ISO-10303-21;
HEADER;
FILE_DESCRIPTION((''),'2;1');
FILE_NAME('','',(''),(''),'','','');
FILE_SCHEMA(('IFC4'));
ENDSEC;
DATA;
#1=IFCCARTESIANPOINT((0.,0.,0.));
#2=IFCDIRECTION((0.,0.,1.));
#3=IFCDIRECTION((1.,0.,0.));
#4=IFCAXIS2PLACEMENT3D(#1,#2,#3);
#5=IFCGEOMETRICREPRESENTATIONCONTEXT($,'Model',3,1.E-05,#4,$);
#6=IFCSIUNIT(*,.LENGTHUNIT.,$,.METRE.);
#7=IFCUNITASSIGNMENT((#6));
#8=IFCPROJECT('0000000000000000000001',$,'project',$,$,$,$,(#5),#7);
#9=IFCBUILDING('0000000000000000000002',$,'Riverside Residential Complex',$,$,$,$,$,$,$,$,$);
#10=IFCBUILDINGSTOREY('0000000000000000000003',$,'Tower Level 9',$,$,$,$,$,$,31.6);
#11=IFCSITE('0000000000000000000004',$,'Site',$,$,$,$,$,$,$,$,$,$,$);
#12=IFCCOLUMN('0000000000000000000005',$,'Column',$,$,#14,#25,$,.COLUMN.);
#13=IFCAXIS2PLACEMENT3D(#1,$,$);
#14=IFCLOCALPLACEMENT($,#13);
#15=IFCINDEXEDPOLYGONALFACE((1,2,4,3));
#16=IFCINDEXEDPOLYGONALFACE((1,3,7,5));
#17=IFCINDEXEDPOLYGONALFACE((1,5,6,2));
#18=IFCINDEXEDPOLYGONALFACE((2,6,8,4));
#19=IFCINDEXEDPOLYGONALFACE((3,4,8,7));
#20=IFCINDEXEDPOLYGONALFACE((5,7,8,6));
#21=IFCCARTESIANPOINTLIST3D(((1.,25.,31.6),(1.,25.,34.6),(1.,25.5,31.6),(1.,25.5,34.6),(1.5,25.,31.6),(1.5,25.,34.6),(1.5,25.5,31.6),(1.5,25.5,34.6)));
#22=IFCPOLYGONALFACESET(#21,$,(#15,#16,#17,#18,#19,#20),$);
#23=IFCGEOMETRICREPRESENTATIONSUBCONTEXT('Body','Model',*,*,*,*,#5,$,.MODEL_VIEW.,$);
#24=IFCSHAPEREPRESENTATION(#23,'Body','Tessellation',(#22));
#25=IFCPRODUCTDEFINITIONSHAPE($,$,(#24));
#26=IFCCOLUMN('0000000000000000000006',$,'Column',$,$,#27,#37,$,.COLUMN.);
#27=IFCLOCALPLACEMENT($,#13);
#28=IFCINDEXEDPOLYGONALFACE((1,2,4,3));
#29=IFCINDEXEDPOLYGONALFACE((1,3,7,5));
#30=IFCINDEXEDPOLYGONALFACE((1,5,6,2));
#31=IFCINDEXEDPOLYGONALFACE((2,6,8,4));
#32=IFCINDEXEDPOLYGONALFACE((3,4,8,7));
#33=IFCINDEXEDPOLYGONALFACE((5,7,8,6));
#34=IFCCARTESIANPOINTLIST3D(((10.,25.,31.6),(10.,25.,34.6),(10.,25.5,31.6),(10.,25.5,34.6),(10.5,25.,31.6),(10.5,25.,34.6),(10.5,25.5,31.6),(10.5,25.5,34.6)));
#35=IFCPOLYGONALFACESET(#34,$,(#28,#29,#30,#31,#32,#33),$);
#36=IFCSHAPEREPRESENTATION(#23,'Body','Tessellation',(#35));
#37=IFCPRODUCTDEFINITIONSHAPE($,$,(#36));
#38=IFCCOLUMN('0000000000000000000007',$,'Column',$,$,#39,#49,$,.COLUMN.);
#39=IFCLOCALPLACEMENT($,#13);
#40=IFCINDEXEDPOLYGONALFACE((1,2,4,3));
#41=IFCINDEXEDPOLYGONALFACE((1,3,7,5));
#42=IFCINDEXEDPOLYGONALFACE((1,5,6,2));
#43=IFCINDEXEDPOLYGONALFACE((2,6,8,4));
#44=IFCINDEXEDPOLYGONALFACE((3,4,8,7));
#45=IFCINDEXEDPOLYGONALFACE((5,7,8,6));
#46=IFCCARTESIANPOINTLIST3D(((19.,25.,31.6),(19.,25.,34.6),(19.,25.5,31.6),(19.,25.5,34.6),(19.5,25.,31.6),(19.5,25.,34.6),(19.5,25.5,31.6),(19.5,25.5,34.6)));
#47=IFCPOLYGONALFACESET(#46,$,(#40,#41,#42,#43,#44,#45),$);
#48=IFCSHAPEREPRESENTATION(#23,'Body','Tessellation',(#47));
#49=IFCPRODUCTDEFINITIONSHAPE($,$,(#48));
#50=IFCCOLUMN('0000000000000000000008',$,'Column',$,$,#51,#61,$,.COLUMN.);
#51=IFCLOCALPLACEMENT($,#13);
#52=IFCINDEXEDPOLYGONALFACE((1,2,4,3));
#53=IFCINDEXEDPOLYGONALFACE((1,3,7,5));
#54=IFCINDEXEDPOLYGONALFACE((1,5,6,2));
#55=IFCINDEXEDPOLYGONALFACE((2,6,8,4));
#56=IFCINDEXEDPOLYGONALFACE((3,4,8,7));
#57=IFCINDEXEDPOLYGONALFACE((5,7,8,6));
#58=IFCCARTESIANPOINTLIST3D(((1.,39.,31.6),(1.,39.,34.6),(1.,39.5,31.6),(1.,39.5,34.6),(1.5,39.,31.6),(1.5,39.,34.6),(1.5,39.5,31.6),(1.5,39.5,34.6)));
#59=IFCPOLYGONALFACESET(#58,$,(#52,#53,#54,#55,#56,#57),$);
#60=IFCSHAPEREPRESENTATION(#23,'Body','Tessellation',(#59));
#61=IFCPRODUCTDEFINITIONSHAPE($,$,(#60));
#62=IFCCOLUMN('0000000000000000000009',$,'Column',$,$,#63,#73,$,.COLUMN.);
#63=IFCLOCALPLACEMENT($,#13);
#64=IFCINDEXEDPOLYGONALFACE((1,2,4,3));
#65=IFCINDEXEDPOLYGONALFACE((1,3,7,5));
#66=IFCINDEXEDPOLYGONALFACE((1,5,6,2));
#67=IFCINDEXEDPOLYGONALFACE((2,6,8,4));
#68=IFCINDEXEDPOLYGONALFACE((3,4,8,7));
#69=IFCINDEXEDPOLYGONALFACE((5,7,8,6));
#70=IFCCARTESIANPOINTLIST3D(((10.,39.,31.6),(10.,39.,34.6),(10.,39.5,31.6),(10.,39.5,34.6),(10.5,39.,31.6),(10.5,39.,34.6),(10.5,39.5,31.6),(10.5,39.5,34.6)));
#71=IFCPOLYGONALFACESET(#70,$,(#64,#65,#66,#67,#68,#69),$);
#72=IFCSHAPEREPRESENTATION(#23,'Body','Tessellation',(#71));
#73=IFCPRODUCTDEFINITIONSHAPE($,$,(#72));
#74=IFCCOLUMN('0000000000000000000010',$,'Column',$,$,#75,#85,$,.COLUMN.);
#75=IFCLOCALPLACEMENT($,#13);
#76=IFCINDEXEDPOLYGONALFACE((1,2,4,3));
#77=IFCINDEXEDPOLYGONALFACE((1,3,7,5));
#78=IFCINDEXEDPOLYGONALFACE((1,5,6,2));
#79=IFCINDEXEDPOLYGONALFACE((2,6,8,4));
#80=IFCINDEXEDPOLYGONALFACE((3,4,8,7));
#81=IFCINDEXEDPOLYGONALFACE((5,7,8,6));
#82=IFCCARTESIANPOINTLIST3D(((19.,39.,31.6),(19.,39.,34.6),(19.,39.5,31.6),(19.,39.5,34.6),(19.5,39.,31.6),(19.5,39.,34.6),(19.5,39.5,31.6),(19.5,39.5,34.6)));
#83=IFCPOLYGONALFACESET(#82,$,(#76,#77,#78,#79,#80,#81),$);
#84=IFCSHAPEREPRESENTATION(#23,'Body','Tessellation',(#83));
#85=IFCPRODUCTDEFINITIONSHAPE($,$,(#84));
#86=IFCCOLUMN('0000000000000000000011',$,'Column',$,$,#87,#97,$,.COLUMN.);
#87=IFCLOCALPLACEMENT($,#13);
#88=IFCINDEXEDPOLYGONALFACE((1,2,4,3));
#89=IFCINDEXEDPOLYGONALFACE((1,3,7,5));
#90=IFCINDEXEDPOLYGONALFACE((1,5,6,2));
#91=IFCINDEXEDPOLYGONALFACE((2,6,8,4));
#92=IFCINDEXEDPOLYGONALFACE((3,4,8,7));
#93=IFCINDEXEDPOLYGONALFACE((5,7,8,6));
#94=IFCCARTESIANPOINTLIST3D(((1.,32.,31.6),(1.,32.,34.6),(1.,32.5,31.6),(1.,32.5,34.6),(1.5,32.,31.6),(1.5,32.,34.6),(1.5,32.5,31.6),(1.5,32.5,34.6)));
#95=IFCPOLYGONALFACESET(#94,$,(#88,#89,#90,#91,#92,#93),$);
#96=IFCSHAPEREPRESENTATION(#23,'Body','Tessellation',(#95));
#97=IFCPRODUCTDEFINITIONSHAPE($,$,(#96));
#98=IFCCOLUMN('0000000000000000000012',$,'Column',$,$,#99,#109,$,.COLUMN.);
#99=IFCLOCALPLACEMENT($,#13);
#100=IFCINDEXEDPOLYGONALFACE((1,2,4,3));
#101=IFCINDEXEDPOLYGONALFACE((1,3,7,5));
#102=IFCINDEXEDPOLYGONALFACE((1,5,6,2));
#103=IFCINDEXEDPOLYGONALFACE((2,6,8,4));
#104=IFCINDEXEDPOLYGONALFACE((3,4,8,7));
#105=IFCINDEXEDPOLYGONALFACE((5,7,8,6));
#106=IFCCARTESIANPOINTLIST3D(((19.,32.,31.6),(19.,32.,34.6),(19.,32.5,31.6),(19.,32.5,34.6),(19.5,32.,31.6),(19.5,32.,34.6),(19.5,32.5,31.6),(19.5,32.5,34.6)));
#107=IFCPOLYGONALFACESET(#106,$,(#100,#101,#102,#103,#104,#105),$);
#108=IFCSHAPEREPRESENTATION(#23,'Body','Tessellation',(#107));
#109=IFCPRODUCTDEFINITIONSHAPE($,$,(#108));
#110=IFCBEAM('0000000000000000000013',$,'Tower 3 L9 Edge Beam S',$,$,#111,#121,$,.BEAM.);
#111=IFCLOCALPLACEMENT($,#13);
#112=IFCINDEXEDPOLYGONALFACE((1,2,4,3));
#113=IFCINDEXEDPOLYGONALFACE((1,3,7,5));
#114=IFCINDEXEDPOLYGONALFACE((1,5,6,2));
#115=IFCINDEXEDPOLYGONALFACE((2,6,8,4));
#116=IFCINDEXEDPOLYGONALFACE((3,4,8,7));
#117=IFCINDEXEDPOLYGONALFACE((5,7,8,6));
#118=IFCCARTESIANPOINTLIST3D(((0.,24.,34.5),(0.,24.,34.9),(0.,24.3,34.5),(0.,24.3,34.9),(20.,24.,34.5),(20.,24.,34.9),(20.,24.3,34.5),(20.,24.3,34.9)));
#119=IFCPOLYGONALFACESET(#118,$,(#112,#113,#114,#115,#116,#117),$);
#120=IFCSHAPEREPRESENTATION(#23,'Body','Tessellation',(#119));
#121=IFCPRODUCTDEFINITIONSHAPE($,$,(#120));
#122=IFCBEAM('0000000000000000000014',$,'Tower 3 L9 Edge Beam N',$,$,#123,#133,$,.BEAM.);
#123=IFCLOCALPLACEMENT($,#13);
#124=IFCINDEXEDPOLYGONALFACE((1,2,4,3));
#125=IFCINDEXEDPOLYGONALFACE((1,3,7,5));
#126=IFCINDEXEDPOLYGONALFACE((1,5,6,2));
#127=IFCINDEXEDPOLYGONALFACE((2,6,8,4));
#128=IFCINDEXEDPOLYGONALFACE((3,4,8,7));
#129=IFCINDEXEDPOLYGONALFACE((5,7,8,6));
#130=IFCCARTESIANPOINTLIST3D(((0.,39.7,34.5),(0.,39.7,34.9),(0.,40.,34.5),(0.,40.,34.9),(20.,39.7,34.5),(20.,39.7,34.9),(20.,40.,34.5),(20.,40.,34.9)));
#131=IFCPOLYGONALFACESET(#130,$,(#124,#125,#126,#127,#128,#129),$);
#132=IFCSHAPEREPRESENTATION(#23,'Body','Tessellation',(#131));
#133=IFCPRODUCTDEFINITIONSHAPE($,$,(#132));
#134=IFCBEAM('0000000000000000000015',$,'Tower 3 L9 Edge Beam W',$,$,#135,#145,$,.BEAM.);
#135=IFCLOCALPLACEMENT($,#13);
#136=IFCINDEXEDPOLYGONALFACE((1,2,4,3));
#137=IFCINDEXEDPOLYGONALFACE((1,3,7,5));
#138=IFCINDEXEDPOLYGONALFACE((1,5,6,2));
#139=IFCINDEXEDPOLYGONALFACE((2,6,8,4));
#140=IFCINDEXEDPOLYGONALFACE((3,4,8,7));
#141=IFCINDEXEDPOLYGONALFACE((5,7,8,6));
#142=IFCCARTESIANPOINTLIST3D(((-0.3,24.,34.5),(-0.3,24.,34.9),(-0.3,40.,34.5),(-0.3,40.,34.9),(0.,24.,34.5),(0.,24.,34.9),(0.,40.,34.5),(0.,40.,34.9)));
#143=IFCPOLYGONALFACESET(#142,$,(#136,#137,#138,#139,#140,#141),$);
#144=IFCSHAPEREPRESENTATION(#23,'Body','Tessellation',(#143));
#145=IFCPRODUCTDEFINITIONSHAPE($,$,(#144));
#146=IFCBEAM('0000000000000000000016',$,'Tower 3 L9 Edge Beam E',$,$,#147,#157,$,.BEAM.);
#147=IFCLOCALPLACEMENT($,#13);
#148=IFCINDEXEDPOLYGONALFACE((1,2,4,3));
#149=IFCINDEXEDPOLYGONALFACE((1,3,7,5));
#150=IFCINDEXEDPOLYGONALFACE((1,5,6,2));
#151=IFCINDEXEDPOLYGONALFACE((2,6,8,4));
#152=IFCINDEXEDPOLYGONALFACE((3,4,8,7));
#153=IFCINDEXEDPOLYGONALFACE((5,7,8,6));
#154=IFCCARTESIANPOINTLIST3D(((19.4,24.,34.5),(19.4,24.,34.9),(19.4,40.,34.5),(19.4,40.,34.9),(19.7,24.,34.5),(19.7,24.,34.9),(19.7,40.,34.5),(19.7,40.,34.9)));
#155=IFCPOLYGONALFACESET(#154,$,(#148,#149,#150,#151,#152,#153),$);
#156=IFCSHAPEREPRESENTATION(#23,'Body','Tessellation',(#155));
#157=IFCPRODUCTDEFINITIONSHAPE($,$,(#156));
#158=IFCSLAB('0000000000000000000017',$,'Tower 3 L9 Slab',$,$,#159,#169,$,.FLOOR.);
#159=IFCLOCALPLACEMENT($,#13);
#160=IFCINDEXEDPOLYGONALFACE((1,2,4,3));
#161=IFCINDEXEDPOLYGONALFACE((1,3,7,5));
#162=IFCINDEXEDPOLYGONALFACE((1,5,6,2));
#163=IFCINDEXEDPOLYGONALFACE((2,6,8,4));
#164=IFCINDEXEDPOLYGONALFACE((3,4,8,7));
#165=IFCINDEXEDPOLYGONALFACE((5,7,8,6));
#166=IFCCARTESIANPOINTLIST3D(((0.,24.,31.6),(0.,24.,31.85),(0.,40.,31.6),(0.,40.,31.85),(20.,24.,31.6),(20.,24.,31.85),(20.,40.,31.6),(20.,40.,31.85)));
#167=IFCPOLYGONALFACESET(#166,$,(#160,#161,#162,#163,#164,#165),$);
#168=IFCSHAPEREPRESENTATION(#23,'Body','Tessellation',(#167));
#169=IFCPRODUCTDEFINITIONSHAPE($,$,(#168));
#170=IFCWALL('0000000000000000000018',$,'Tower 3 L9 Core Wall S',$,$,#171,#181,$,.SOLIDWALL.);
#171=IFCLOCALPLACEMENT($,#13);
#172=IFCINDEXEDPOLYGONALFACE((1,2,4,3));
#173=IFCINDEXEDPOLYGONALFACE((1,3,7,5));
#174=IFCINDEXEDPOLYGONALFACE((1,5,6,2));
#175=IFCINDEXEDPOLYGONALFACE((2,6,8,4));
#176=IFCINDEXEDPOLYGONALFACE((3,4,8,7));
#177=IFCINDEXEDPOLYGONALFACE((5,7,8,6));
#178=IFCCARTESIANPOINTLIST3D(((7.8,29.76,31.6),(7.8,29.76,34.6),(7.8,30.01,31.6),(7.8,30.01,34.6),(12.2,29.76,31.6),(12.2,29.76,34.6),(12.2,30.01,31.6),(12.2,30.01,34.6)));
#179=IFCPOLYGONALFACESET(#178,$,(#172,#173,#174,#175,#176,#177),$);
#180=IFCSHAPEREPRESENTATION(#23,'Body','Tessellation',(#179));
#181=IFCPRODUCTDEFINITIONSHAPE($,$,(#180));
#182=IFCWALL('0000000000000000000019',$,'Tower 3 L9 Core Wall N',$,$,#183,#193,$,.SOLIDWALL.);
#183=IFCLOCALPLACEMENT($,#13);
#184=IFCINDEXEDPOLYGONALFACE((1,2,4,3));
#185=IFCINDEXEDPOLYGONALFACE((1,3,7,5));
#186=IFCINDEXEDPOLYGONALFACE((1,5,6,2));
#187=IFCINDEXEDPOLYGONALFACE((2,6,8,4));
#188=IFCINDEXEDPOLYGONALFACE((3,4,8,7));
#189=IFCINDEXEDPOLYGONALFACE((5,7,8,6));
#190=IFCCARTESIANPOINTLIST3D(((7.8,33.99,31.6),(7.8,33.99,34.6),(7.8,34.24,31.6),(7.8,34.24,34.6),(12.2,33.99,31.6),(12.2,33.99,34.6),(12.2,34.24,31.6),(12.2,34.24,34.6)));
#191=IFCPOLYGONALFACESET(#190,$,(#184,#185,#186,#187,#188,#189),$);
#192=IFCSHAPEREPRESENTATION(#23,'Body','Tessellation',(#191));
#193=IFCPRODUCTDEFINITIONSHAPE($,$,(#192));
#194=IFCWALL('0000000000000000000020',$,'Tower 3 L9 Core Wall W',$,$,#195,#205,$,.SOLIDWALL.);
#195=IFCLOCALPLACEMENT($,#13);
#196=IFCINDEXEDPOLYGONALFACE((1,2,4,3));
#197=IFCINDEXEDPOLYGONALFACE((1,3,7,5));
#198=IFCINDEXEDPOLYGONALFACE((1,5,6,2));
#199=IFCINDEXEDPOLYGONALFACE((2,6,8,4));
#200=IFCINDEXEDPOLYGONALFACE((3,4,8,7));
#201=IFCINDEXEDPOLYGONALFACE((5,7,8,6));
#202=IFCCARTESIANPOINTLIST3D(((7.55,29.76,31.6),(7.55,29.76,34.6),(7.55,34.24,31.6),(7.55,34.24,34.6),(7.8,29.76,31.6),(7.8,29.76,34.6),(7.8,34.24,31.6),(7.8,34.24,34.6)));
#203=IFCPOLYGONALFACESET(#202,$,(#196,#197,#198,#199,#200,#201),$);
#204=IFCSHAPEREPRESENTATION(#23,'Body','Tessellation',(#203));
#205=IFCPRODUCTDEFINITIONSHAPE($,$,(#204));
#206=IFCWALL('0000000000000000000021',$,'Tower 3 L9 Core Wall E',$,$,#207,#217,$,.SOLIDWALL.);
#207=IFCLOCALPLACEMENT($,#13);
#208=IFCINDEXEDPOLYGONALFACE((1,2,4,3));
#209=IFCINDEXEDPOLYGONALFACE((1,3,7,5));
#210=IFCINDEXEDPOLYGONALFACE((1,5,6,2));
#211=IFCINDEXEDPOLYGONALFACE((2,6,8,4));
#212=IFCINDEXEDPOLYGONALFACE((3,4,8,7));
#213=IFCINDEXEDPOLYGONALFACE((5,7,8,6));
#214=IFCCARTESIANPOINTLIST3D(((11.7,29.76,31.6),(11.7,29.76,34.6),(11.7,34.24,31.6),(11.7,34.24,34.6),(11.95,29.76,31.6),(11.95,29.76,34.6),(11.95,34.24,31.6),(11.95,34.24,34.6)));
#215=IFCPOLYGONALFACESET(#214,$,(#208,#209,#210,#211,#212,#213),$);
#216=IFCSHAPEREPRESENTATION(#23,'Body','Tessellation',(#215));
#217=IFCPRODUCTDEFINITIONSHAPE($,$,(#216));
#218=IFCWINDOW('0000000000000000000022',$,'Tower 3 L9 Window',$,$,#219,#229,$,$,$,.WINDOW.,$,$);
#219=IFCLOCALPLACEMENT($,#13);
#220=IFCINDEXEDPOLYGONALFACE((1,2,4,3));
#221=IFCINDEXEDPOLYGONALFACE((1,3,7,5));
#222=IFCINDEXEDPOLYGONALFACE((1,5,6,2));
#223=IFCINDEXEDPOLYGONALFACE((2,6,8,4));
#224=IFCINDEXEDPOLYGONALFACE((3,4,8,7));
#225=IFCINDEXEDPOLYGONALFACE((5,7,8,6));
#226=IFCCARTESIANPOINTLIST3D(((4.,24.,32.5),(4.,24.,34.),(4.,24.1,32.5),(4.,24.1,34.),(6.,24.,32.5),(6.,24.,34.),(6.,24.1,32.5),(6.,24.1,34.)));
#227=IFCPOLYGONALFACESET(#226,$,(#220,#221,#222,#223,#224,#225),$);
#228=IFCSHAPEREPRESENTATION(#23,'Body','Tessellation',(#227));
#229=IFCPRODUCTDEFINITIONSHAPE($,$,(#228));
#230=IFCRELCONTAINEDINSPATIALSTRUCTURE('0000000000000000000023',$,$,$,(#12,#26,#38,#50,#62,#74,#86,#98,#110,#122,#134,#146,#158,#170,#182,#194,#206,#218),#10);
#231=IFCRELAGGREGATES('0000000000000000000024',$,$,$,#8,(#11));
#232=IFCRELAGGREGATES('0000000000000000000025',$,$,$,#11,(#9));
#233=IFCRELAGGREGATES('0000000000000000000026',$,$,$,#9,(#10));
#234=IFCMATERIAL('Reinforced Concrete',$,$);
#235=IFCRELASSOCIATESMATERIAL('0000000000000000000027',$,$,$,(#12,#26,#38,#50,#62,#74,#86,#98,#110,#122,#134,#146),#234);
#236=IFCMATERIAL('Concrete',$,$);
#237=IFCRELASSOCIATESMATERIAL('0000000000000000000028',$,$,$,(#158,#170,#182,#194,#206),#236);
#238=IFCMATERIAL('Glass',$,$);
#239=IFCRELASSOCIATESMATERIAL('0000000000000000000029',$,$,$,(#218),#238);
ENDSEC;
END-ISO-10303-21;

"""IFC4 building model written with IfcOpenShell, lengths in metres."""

from ifc_helpers import new_model, si_unit, frame, origin_with_axes, place, context, subcontext, project, spatial, line, indexed_curve, outline, extrude, material, element, save


model = new_model("IFC4")

# Units and contexts
model_context = context("Model", 3, precision=1e-05, world=origin_with_axes())
body_context = subcontext(model_context, "Body", "Model", "MODEL_VIEW")
ifc_project = project(units=[si_unit("LENGTHUNIT", "METRE")], contexts=[model_context])

# Site, building, storey
site = spatial("IfcSite", under=ifc_project, Name="Site")
building = spatial("IfcBuilding", under=site, Name="Riverside Residential Complex")
storey = spatial("IfcBuildingStorey", under=building, Name="Tower Level 9", Elevation=31.6)

# Columns
ifc_material_1 = material(Name="Reinforced Concrete")
for number, where, z_axis, x_axis, name in (
    (1, (1.0, 25.0, 31.6), (0.0, 0.0, 1.0), (1.0, 0.0, 0.0), "Column"),
    (2, (10.0, 25.0, 31.6), (0.0, 0.0, 1.0), (1.0, 0.0, 0.0), "Column"),
    (3, (19.0, 25.0, 31.6), (0.0, 0.0, 1.0), (1.0, 0.0, 0.0), "Column"),
    (4, (1.0, 39.0, 31.6), (0.0, 0.0, 1.0), (1.0, 0.0, 0.0), "Column"),
    (5, (10.0, 39.0, 31.6), (0.0, 0.0, 1.0), (1.0, 0.0, 0.0), "Column"),
    (6, (19.0, 39.0, 31.6), (0.0, 0.0, 1.0), (1.0, 0.0, 0.0), "Column"),
    (7, (1.0, 32.0, 31.6), (0.0, 0.0, 1.0), (1.0, 0.0, 0.0), "Column"),
    (8, (19.0, 32.0, 31.6), (0.0, 0.0, 1.0), (1.0, 0.0, 0.0), "Column"),
):
    element("IfcColumn", number, at=place(None, frame(where, z_axis=z_axis, x_axis=x_axis)), inside=storey, material=ifc_material_1, Name=name, PredefinedType="COLUMN", context=body_context, shape_type="SweptSolid", body=[
        extrude(outline(indexed_curve([(0.0, 0.0), (0.5, 0.0), (0.5, 0.5), (0.0, 0.5)], segments=[line(1, 2, 3, 4, 1)])), origin_with_axes(), (0.0, 0.0, 1.0), 3.0),
    ])

# Beams
for number, where, z_axis, x_axis, name in (
    (9, (0.0, 24.0, 34.5), (0.0, 0.0, 1.0), (1.0, 0.0, 0.0), "Tower 3 L9 Edge Beam S"),
    (10, (0.0, 39.7, 34.5), (0.0, 0.0, 1.0), (1.0, 0.0, 0.0), "Tower 3 L9 Edge Beam N"),
):
    element("IfcBeam", number, at=place(None, frame(where, z_axis=z_axis, x_axis=x_axis)), inside=storey, material=ifc_material_1, Name=name, PredefinedType="BEAM", context=body_context, shape_type="SweptSolid", body=[
        extrude(outline(indexed_curve([(0.0, 0.0), (20.0, 0.0), (20.0, 0.3), (0.0, 0.3)], segments=[line(1, 2, 3, 4, 1)])), origin_with_axes(), (0.0, 0.0, 1.0), 0.4),
    ])
for number, where, z_axis, x_axis, name in (
    (11, (0.0, 24.0, 34.5), (0.0, 0.0, 1.0), (0.0, 1.0, 0.0), "Tower 3 L9 Edge Beam W"),
    (12, (19.7, 24.0, 34.5), (0.0, 0.0, 1.0), (0.0, 1.0, 0.0), "Tower 3 L9 Edge Beam E"),
):
    element("IfcBeam", number, at=place(None, frame(where, z_axis=z_axis, x_axis=x_axis)), inside=storey, material=ifc_material_1, Name=name, PredefinedType="BEAM", context=body_context, shape_type="SweptSolid", body=[
        extrude(outline(indexed_curve([(0.0, 0.0), (16.0, 0.0), (16.0, 0.3), (0.0, 0.3)], segments=[line(1, 2, 3, 4, 1)])), origin_with_axes(), (0.0, 0.0, 1.0), 0.4),
    ])

# Slab
ifc_material_2 = material(Name="Concrete")
slab_placement = place(None, frame((0.0, 24.0, 31.6), z_axis=(0.0, 0.0, 1.0), x_axis=(1.0, 0.0, 0.0)))
element("IfcSlab", 13, at=slab_placement, inside=storey, material=ifc_material_2, Name="Tower 3 L9 Slab", PredefinedType="FLOOR", context=body_context, shape_type="SweptSolid", body=[
    extrude(outline(indexed_curve([(0.0, 0.0), (20.0, 0.0), (20.0, 16.0), (0.0, 16.0)], segments=[line(1, 2, 3, 4, 1)])), origin_with_axes(), (0.0, 0.0, 1.0), 0.25),
])

# Walls
for number, where, z_axis, x_axis, name in (
    (14, (7.8, 29.76, 31.6), (0.0, 0.0, 1.0), (1.0, 0.0, 0.0), "Tower 3 L9 Core Wall S"),
    (15, (7.8, 33.99, 31.6), (0.0, 0.0, 1.0), (1.0, 0.0, 0.0), "Tower 3 L9 Core Wall N"),
):
    element("IfcWall", number, at=place(None, frame(where, z_axis=z_axis, x_axis=x_axis)), inside=storey, material=ifc_material_2, Name=name, PredefinedType="SOLIDWALL", context=body_context, shape_type="SweptSolid", body=[
        extrude(outline(indexed_curve([(0.0, 0.0), (4.4, 0.0), (4.4, 0.25), (0.0, 0.25)], segments=[line(1, 2, 3, 4, 1)])), origin_with_axes(), (0.0, 0.0, 1.0), 3.0),
    ])
for number, where, z_axis, x_axis, name in (
    (16, (7.8, 29.76, 31.6), (0.0, 0.0, 1.0), (0.0, 1.0, 0.0), "Tower 3 L9 Core Wall W"),
    (17, (11.95, 29.76, 31.6), (0.0, 0.0, 1.0), (0.0, 1.0, 0.0), "Tower 3 L9 Core Wall E"),
):
    element("IfcWall", number, at=place(None, frame(where, z_axis=z_axis, x_axis=x_axis)), inside=storey, material=ifc_material_2, Name=name, PredefinedType="SOLIDWALL", context=body_context, shape_type="SweptSolid", body=[
        extrude(outline(indexed_curve([(0.0, 0.0), (4.48, 0.0), (4.48, 0.25), (0.0, 0.25)], segments=[line(1, 2, 3, 4, 1)])), origin_with_axes(), (0.0, 0.0, 1.0), 3.0),
    ])

# Window
ifc_material_3 = material(Name="Glass")
for number, where, z_axis, x_axis, name in (
    (18, (4.0, 24.0, 32.5), (0.0, 0.0, 1.0), (1.0, 0.0, 0.0), "Tower 3 L9 Window"),
):
    element("IfcWindow", number, at=place(None, frame(where, z_axis=z_axis, x_axis=x_axis)), inside=storey, material=ifc_material_3, Name=name, PredefinedType="WINDOW", context=body_context, shape_type="SweptSolid", body=[
        extrude(outline(indexed_curve([(0.0, 0.0), (2.0, 0.0), (2.0, 0.1), (0.0, 0.1)], segments=[line(1, 2, 3, 4, 1)])), origin_with_axes(), (0.0, 0.0, 1.0), 1.5),
    ])

save(model, "model.ifc")
